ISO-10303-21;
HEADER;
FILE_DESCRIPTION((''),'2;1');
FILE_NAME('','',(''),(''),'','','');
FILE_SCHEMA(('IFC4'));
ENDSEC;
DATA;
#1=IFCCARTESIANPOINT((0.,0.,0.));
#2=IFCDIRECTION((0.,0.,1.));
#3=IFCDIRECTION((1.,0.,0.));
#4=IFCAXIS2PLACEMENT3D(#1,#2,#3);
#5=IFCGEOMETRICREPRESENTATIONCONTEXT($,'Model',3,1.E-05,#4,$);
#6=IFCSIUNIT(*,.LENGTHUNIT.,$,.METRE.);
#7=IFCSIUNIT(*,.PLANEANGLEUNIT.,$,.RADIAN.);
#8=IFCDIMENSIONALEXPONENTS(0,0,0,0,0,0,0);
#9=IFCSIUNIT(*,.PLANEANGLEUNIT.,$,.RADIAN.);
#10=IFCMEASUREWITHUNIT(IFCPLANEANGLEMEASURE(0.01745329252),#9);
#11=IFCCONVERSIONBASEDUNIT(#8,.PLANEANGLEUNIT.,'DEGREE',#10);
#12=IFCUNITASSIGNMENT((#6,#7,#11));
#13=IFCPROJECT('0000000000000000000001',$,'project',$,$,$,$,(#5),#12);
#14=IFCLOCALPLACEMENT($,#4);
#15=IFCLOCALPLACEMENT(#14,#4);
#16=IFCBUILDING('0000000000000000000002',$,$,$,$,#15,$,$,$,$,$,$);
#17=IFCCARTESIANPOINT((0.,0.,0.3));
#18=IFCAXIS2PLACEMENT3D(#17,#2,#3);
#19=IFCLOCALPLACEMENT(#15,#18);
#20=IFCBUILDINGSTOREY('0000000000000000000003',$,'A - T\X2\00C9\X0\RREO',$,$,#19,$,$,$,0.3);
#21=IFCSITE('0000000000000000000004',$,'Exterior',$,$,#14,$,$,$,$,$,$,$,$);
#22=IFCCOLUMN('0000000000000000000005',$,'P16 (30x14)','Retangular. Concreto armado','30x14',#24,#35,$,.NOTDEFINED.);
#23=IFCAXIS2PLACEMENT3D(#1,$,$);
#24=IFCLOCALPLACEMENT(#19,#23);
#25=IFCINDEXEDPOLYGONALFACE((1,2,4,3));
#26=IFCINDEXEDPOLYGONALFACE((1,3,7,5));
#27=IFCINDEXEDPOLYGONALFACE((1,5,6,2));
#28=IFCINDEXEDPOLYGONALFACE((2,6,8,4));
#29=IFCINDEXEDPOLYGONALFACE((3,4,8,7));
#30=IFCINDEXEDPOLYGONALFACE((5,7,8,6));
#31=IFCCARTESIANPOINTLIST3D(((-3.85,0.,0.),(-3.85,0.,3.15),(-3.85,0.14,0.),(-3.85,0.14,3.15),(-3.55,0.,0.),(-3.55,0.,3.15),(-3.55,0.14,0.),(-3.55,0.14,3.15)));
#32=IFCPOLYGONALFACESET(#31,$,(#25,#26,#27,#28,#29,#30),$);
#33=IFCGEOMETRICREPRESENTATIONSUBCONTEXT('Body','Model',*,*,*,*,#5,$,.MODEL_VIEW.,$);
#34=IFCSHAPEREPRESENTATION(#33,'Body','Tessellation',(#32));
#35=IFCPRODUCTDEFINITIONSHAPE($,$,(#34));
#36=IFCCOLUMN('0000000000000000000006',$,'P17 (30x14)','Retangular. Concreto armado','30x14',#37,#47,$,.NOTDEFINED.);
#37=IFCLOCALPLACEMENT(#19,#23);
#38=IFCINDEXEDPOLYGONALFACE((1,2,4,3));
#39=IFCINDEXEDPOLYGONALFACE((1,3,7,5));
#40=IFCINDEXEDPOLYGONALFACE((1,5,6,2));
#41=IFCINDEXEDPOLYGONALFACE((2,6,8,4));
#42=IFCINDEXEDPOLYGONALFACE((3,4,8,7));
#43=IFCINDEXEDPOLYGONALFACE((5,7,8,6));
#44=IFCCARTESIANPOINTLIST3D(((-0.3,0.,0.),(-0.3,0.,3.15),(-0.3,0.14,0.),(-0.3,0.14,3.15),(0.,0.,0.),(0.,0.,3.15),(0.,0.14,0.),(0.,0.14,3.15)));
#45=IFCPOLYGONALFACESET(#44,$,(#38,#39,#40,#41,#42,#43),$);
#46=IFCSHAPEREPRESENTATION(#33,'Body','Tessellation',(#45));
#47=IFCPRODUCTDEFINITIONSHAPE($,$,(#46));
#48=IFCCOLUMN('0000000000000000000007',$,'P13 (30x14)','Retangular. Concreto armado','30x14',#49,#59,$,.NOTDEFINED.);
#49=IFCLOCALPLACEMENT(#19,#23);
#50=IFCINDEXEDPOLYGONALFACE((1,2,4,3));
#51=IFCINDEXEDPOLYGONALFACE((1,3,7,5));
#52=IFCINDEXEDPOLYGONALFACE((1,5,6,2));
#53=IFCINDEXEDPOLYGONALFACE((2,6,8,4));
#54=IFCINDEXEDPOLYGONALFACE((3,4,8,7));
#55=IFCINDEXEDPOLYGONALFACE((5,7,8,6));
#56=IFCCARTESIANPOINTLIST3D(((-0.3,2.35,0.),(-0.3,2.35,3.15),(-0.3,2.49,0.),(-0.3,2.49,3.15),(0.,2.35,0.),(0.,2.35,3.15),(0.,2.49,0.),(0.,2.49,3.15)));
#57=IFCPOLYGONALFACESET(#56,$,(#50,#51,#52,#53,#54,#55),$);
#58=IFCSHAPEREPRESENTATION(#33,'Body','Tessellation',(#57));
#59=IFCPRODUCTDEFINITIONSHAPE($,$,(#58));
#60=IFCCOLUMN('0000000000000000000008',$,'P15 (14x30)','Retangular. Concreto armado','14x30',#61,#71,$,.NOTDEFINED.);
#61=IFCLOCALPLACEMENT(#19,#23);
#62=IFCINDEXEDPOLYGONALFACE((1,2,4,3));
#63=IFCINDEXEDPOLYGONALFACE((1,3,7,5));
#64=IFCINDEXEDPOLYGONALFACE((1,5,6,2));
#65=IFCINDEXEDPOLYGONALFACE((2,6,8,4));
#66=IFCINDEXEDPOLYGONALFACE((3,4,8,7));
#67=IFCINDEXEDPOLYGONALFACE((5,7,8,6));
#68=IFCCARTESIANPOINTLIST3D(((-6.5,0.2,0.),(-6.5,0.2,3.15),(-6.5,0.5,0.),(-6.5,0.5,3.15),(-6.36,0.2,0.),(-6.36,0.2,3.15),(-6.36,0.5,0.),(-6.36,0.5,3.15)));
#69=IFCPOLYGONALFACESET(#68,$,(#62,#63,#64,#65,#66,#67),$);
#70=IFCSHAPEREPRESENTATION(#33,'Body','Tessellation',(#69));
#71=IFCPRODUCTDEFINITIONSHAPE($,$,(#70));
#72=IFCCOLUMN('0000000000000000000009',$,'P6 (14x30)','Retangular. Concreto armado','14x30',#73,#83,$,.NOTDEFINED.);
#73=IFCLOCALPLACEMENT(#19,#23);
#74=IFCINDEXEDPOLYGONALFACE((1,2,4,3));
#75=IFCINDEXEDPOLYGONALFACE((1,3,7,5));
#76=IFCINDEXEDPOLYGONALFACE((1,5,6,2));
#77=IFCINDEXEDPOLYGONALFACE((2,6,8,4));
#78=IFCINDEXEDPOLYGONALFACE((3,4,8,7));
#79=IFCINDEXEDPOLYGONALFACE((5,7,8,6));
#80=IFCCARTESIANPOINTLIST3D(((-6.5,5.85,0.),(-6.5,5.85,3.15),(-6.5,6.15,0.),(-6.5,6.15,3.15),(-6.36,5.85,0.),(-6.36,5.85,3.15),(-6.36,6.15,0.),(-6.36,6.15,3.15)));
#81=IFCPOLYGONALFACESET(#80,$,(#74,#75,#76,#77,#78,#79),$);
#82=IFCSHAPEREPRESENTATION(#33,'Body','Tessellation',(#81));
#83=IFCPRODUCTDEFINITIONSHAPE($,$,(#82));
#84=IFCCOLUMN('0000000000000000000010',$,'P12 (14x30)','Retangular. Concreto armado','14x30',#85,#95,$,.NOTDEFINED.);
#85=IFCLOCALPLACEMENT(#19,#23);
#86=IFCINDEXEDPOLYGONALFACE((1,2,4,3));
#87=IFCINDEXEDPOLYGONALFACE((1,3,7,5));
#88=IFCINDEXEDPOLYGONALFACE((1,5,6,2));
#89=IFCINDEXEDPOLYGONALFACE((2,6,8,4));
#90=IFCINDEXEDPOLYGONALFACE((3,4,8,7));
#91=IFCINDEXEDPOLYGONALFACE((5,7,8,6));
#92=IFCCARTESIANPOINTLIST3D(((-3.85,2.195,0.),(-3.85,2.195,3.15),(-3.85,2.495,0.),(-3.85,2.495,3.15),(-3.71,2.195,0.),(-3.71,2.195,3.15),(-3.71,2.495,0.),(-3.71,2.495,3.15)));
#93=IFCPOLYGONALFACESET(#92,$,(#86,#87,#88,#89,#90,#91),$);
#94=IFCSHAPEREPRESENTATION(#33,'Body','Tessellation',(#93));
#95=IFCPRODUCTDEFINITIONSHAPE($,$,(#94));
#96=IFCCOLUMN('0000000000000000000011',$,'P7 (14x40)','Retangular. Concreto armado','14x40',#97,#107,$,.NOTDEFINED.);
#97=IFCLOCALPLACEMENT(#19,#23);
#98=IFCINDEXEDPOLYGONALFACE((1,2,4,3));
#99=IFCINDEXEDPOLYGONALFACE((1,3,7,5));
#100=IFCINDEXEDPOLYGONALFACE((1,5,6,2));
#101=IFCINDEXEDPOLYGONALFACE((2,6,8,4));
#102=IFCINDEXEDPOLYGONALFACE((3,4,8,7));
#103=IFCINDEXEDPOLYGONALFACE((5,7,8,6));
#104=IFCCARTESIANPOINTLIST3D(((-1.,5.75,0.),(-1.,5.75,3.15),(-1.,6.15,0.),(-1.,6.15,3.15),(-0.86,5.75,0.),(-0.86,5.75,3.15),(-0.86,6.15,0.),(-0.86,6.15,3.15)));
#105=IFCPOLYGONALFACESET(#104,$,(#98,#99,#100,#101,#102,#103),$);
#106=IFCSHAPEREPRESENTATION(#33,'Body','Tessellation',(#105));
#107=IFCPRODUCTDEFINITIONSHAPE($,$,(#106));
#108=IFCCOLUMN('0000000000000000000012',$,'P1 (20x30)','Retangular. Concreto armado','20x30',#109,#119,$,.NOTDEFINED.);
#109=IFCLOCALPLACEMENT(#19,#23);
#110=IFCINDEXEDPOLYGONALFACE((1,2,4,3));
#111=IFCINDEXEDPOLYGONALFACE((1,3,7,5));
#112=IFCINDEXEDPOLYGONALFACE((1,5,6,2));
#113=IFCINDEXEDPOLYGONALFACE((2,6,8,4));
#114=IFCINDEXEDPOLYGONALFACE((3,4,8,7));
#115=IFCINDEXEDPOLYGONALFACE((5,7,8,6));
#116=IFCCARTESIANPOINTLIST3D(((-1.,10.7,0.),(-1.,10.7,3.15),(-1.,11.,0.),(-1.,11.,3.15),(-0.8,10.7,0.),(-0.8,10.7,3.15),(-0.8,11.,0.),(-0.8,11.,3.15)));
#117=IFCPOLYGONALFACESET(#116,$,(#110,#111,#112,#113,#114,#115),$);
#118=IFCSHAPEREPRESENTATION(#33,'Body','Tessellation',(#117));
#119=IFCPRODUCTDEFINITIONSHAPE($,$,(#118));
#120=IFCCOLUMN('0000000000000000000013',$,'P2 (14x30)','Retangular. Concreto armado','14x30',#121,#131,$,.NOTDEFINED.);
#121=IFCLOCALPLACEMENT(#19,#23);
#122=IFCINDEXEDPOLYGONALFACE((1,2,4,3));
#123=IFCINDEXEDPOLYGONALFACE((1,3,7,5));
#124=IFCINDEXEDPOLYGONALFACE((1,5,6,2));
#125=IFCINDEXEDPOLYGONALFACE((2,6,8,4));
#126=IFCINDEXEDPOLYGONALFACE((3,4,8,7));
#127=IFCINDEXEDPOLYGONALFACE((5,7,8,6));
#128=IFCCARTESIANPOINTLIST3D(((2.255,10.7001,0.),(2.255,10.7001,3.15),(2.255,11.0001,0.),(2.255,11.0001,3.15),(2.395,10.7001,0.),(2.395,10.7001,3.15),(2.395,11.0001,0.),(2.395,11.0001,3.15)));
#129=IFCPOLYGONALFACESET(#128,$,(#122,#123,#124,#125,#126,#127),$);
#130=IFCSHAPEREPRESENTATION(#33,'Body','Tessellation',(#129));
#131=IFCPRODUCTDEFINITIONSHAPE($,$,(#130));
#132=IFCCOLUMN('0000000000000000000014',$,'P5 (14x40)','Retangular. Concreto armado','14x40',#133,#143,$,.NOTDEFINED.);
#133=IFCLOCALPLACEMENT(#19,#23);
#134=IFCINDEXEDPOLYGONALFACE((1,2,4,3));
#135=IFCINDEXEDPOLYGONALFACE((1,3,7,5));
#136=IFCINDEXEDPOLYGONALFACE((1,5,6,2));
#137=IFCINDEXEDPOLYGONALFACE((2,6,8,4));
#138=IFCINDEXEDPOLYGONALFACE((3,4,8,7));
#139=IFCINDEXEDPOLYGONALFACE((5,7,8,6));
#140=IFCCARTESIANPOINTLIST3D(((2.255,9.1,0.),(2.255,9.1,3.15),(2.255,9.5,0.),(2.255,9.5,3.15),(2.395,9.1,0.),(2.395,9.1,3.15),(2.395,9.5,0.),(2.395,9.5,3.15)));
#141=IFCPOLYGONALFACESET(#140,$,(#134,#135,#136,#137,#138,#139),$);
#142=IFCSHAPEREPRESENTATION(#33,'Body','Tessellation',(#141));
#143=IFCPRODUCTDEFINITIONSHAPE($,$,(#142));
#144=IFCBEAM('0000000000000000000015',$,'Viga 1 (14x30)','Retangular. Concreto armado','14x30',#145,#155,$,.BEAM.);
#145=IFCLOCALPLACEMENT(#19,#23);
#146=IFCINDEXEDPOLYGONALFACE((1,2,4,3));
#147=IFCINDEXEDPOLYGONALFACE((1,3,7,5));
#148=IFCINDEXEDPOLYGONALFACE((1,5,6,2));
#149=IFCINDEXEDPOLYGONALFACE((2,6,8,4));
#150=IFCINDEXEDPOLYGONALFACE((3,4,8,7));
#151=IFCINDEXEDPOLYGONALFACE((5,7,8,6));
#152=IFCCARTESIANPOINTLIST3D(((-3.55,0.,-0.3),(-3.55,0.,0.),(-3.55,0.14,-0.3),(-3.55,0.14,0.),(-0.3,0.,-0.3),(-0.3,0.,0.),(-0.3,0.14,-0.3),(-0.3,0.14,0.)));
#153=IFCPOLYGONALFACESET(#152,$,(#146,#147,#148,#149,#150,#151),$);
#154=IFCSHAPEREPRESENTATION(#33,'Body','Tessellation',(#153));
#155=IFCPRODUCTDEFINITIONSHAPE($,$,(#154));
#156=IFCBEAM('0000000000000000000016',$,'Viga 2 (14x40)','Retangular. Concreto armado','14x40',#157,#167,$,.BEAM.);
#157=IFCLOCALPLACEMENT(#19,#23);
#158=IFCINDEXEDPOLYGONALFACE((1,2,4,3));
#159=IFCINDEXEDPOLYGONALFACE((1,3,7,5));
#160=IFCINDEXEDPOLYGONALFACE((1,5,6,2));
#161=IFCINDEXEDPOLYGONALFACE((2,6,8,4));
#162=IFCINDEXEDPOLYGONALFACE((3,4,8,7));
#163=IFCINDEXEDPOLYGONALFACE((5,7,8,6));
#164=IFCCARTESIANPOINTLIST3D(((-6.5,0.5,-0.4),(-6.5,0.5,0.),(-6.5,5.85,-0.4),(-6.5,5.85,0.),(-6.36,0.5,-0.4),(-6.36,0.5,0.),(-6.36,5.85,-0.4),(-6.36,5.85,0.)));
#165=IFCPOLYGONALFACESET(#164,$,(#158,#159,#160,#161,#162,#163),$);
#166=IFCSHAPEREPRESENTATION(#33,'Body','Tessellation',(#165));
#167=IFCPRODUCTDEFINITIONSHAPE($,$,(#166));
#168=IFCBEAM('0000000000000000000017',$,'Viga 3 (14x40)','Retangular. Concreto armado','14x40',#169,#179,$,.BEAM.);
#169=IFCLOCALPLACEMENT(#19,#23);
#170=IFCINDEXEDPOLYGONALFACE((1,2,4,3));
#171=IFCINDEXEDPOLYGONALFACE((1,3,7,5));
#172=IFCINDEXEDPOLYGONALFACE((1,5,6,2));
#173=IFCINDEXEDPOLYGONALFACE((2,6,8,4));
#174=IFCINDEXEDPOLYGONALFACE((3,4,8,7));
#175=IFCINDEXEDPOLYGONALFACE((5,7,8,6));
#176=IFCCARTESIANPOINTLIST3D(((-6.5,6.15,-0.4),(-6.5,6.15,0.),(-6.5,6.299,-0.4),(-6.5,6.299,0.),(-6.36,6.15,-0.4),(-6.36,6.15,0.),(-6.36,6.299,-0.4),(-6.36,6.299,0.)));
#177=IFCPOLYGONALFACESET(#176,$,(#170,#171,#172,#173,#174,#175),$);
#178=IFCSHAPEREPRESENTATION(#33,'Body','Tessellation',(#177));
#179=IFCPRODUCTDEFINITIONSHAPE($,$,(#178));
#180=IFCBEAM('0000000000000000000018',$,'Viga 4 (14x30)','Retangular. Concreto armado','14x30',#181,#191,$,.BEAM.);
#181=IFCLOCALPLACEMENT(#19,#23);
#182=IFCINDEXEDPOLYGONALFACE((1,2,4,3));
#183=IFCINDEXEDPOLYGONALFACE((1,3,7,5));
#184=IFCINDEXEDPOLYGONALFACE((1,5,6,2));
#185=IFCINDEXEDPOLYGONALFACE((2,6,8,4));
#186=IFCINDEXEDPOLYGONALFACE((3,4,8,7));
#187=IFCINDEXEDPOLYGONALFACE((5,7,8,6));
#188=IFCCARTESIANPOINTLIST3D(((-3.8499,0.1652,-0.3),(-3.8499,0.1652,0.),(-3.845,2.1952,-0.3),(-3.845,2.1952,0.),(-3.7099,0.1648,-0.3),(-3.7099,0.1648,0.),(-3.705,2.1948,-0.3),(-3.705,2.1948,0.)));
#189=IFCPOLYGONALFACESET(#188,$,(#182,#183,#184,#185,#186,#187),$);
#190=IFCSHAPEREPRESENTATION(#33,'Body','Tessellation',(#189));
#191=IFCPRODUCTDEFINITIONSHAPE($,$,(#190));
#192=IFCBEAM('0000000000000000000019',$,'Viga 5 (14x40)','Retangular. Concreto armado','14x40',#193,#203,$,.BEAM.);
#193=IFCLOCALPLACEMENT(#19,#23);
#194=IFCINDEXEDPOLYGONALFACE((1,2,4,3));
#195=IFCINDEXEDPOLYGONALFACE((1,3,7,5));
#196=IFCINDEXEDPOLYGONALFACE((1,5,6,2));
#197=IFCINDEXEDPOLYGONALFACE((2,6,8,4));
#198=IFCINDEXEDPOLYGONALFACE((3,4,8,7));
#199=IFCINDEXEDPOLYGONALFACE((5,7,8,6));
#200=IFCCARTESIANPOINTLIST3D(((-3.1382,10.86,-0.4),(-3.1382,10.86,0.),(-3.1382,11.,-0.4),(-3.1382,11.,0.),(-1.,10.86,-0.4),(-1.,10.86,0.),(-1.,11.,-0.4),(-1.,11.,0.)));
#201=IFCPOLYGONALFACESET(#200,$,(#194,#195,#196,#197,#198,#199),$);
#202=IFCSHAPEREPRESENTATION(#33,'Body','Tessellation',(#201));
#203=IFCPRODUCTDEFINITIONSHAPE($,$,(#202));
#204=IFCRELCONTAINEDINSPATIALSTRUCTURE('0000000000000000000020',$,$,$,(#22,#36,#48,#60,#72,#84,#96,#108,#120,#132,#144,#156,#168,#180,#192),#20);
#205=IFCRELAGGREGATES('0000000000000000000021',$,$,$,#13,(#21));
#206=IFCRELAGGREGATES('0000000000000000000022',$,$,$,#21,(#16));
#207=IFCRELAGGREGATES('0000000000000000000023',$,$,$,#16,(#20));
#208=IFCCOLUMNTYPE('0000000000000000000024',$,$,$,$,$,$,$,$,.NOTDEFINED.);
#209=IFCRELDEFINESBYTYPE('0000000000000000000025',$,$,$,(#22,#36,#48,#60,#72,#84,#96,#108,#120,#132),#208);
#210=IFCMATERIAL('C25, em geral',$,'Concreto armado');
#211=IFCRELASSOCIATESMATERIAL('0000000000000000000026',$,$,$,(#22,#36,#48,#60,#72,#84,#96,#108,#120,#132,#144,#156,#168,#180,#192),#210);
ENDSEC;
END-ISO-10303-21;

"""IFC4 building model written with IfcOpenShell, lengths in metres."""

from ifc_helpers import new_model, entity, si_unit, converted_unit, frame, frame_2d, origin_with_axes, origin_2d_with_axis, place, context, subcontext, project, spatial, rectangle, extrude, material, type_object, element, save


model = new_model("IFC4")

# Units and contexts
model_context = context("Model", 3, precision=1e-05, world=origin_with_axes())
body_context = subcontext(model_context, "Body", "Model", "MODEL_VIEW")
ifc_project = project(units=[si_unit("LENGTHUNIT", "METRE"), si_unit("PLANEANGLEUNIT", "RADIAN"), converted_unit("PLANEANGLEUNIT", "DEGREE", entity("IfcPlaneAngleMeasure", 0.01745329252), si_unit("PLANEANGLEUNIT", "RADIAN"), dimensions=[0, 0, 0, 0, 0, 0, 0])], contexts=[model_context])

# Site, building, storey
site_placement = place(None, origin_with_axes())
site = spatial("IfcSite", under=ifc_project, at=site_placement, Name="Exterior")
building_placement = place(site_placement, origin_with_axes())
building = spatial("IfcBuilding", under=site, at=building_placement)
storey_placement = place(building_placement, frame((0.0, 0.0, 0.3), z_axis=(0.0, 0.0, 1.0), x_axis=(1.0, 0.0, 0.0)))
storey = spatial("IfcBuildingStorey", under=building, at=storey_placement, Name="A - TÉRREO", Elevation=0.3)

# Columns
ifc_material = material(Name="C25, em geral", Category="Concreto armado")
column_type = type_object("IfcColumnType", PredefinedType="NOTDEFINED")
for number, where, z_axis, x_axis, name in (
    (1, (-3.7, 0.07, 0.0), (0.0, 0.0, 1.0), (1.0, 0.0, 0.0), "P16 (30x14)"),
    (2, (-0.15, 0.07, 0.0), (0.0, 0.0, 1.0), (1.0, 0.0, 0.0), "P17 (30x14)"),
    (3, (-0.15, 2.42, 0.0), (0.0, 0.0, 1.0), (1.0, 0.0, 0.0), "P13 (30x14)"),
):
    element("IfcColumn", number, at=place(storey_placement, frame(where, z_axis=z_axis, x_axis=x_axis)), inside=storey, type_object=column_type, material=ifc_material, Name=name, Description="Retangular. Concreto armado", ObjectType="30x14", PredefinedType="NOTDEFINED", context=body_context, shape_type="SweptSolid", body=[
        extrude(rectangle(XDim=0.3, YDim=0.14, at=origin_2d_with_axis()), origin_with_axes(), (0.0, 0.0, 1.0), 3.15),
    ])
column_1_placement = place(storey_placement, frame((-6.43, 0.35, 0.0), z_axis=(0.0, 0.0, 1.0), x_axis=(1.0, 0.0, 0.0)))
element("IfcColumn", 4, at=column_1_placement, inside=storey, type_object=column_type, material=ifc_material, Name="P15 (14x30)", Description="Retangular. Concreto armado", ObjectType="14x30", PredefinedType="NOTDEFINED", context=body_context, shape_type="SweptSolid", body=[
    extrude(rectangle(XDim=0.14, YDim=0.3, at=origin_2d_with_axis()), origin_with_axes(), (0.0, 0.0, 1.0), 3.15),
])
column_2_placement = place(storey_placement, frame((-6.43, 6.15, 0.0), z_axis=(0.0, 0.0, 1.0), x_axis=(1.0, 0.0, 0.0)))
element("IfcColumn", 5, at=column_2_placement, inside=storey, type_object=column_type, material=ifc_material, Name="P6 (14x30)", Description="Retangular. Concreto armado", ObjectType="14x30", PredefinedType="NOTDEFINED", context=body_context, shape_type="SweptSolid", body=[
    extrude(rectangle(XDim=0.14, YDim=0.3, at=frame_2d((0.0, -0.15), x_axis=(1.0, 0.0))), origin_with_axes(), (0.0, 0.0, 1.0), 3.15),
])
column_3_placement = place(storey_placement, frame((-3.78, 2.345, 0.0), z_axis=(0.0, 0.0, 1.0), x_axis=(1.0, 0.0, 0.0)))
element("IfcColumn", 6, at=column_3_placement, inside=storey, type_object=column_type, material=ifc_material, Name="P12 (14x30)", Description="Retangular. Concreto armado", ObjectType="14x30", PredefinedType="NOTDEFINED", context=body_context, shape_type="SweptSolid", body=[
    extrude(rectangle(XDim=0.14, YDim=0.3, at=origin_2d_with_axis()), origin_with_axes(), (0.0, 0.0, 1.0), 3.15),
])
column_4_placement = place(storey_placement, frame((-0.93, 6.15, 0.0), z_axis=(0.0, 0.0, 1.0), x_axis=(1.0, 0.0, 0.0)))
element("IfcColumn", 7, at=column_4_placement, inside=storey, type_object=column_type, material=ifc_material, Name="P7 (14x40)", Description="Retangular. Concreto armado", ObjectType="14x40", PredefinedType="NOTDEFINED", context=body_context, shape_type="SweptSolid", body=[
    extrude(rectangle(XDim=0.14, YDim=0.4, at=frame_2d((0.0, -0.2), x_axis=(1.0, 0.0))), origin_with_axes(), (0.0, 0.0, 1.0), 3.15),
])
column_5_placement = place(storey_placement, frame((-1.0, 11.0, 0.0), z_axis=(0.0, 0.0, 1.0), x_axis=(1.0, 0.0, 0.0)))
element("IfcColumn", 8, at=column_5_placement, inside=storey, type_object=column_type, material=ifc_material, Name="P1 (20x30)", Description="Retangular. Concreto armado", ObjectType="20x30", PredefinedType="NOTDEFINED", context=body_context, shape_type="SweptSolid", body=[
    extrude(rectangle(XDim=0.2, YDim=0.3, at=frame_2d((0.1, -0.15), x_axis=(1.0, 0.0))), origin_with_axes(), (0.0, 0.0, 1.0), 3.15),
])
column_6_placement = place(storey_placement, frame((2.325, 10.8501, 0.0), z_axis=(0.0, 0.0, 1.0), x_axis=(1.0, 0.0, 0.0)))
element("IfcColumn", 9, at=column_6_placement, inside=storey, type_object=column_type, material=ifc_material, Name="P2 (14x30)", Description="Retangular. Concreto armado", ObjectType="14x30", PredefinedType="NOTDEFINED", context=body_context, shape_type="SweptSolid", body=[
    extrude(rectangle(XDim=0.14, YDim=0.3, at=origin_2d_with_axis()), origin_with_axes(), (0.0, 0.0, 1.0), 3.15),
])
column_7_placement = place(storey_placement, frame((2.325, 9.1, 0.0), z_axis=(0.0, 0.0, 1.0), x_axis=(1.0, 0.0, 0.0)))
element("IfcColumn", 10, at=column_7_placement, inside=storey, type_object=column_type, material=ifc_material, Name="P5 (14x40)", Description="Retangular. Concreto armado", ObjectType="14x40", PredefinedType="NOTDEFINED", context=body_context, shape_type="SweptSolid", body=[
    extrude(rectangle(XDim=0.14, YDim=0.4, at=frame_2d((0.0, 0.2), x_axis=(1.0, 0.0))), origin_with_axes(), (0.0, 0.0, 1.0), 3.15),
])

# Beams
beam_1_placement = place(storey_placement, frame((-3.55, 0.07, 0.0), z_axis=(1.0, 0.0, 0.0), x_axis=(0.0, 1.0, 0.0)))
element("IfcBeam", 11, at=beam_1_placement, inside=storey, material=ifc_material, Name="Viga 1 (14x30)", Description="Retangular. Concreto armado", ObjectType="14x30", PredefinedType="BEAM", context=body_context, shape_type="SweptSolid", body=[
    extrude(rectangle(XDim=0.14, YDim=0.3, at=frame_2d((0.0, -0.15), x_axis=(1.0, 0.0))), origin_with_axes(), (0.0, 0.0, 1.0), 3.25),
])
beam_2_placement = place(storey_placement, frame((-6.43, 0.5, 0.0), z_axis=(0.0, 1.0, 0.0), x_axis=(-1.0, 0.0, 0.0)))
element("IfcBeam", 12, at=beam_2_placement, inside=storey, material=ifc_material, Name="Viga 2 (14x40)", Description="Retangular. Concreto armado", ObjectType="14x40", PredefinedType="BEAM", context=body_context, shape_type="SweptSolid", body=[
    extrude(rectangle(XDim=0.14, YDim=0.4, at=frame_2d((0.0, -0.2), x_axis=(1.0, 0.0))), origin_with_axes(), (0.0, 0.0, 1.0), 5.35),
])
beam_3_placement = place(storey_placement, frame((-6.43, 6.15, 0.0), z_axis=(0.0, 1.0, 0.0), x_axis=(-1.0, 0.0, 0.0)))
element("IfcBeam", 13, at=beam_3_placement, inside=storey, material=ifc_material, Name="Viga 3 (14x40)", Description="Retangular. Concreto armado", ObjectType="14x40", PredefinedType="BEAM", context=body_context, shape_type="SweptSolid", body=[
    extrude(rectangle(XDim=0.14, YDim=0.4, at=frame_2d((0.0, -0.2), x_axis=(1.0, 0.0))), origin_with_axes(), (0.0, 0.0, 1.0), 0.149),
])
beam_4_placement = place(storey_placement, frame((-3.7799, 0.165, 0.0), z_axis=(0.002427, 0.999997, 0.0), x_axis=(-0.999997, 0.002427, 0.0)))
element("IfcBeam", 14, at=beam_4_placement, inside=storey, material=ifc_material, Name="Viga 4 (14x30)", Description="Retangular. Concreto armado", ObjectType="14x30", PredefinedType="BEAM", context=body_context, shape_type="SweptSolid", body=[
    extrude(rectangle(XDim=0.14, YDim=0.3, at=frame_2d((0.0, -0.15), x_axis=(1.0, 0.0))), origin_with_axes(), (0.0, 0.0, 1.0), 2.03),
])
beam_5_placement = place(storey_placement, frame((-3.1382, 10.93, 0.0), z_axis=(1.0, 0.0, 0.0), x_axis=(0.0, 1.0, 0.0)))
element("IfcBeam", 15, at=beam_5_placement, inside=storey, material=ifc_material, Name="Viga 5 (14x40)", Description="Retangular. Concreto armado", ObjectType="14x40", PredefinedType="BEAM", context=body_context, shape_type="SweptSolid", body=[
    extrude(rectangle(XDim=0.14, YDim=0.4, at=frame_2d((0.0, -0.2), x_axis=(1.0, 0.0))), origin_with_axes(), (0.0, 0.0, 1.0), 2.1382),
])

save(model, "model.ifc")
